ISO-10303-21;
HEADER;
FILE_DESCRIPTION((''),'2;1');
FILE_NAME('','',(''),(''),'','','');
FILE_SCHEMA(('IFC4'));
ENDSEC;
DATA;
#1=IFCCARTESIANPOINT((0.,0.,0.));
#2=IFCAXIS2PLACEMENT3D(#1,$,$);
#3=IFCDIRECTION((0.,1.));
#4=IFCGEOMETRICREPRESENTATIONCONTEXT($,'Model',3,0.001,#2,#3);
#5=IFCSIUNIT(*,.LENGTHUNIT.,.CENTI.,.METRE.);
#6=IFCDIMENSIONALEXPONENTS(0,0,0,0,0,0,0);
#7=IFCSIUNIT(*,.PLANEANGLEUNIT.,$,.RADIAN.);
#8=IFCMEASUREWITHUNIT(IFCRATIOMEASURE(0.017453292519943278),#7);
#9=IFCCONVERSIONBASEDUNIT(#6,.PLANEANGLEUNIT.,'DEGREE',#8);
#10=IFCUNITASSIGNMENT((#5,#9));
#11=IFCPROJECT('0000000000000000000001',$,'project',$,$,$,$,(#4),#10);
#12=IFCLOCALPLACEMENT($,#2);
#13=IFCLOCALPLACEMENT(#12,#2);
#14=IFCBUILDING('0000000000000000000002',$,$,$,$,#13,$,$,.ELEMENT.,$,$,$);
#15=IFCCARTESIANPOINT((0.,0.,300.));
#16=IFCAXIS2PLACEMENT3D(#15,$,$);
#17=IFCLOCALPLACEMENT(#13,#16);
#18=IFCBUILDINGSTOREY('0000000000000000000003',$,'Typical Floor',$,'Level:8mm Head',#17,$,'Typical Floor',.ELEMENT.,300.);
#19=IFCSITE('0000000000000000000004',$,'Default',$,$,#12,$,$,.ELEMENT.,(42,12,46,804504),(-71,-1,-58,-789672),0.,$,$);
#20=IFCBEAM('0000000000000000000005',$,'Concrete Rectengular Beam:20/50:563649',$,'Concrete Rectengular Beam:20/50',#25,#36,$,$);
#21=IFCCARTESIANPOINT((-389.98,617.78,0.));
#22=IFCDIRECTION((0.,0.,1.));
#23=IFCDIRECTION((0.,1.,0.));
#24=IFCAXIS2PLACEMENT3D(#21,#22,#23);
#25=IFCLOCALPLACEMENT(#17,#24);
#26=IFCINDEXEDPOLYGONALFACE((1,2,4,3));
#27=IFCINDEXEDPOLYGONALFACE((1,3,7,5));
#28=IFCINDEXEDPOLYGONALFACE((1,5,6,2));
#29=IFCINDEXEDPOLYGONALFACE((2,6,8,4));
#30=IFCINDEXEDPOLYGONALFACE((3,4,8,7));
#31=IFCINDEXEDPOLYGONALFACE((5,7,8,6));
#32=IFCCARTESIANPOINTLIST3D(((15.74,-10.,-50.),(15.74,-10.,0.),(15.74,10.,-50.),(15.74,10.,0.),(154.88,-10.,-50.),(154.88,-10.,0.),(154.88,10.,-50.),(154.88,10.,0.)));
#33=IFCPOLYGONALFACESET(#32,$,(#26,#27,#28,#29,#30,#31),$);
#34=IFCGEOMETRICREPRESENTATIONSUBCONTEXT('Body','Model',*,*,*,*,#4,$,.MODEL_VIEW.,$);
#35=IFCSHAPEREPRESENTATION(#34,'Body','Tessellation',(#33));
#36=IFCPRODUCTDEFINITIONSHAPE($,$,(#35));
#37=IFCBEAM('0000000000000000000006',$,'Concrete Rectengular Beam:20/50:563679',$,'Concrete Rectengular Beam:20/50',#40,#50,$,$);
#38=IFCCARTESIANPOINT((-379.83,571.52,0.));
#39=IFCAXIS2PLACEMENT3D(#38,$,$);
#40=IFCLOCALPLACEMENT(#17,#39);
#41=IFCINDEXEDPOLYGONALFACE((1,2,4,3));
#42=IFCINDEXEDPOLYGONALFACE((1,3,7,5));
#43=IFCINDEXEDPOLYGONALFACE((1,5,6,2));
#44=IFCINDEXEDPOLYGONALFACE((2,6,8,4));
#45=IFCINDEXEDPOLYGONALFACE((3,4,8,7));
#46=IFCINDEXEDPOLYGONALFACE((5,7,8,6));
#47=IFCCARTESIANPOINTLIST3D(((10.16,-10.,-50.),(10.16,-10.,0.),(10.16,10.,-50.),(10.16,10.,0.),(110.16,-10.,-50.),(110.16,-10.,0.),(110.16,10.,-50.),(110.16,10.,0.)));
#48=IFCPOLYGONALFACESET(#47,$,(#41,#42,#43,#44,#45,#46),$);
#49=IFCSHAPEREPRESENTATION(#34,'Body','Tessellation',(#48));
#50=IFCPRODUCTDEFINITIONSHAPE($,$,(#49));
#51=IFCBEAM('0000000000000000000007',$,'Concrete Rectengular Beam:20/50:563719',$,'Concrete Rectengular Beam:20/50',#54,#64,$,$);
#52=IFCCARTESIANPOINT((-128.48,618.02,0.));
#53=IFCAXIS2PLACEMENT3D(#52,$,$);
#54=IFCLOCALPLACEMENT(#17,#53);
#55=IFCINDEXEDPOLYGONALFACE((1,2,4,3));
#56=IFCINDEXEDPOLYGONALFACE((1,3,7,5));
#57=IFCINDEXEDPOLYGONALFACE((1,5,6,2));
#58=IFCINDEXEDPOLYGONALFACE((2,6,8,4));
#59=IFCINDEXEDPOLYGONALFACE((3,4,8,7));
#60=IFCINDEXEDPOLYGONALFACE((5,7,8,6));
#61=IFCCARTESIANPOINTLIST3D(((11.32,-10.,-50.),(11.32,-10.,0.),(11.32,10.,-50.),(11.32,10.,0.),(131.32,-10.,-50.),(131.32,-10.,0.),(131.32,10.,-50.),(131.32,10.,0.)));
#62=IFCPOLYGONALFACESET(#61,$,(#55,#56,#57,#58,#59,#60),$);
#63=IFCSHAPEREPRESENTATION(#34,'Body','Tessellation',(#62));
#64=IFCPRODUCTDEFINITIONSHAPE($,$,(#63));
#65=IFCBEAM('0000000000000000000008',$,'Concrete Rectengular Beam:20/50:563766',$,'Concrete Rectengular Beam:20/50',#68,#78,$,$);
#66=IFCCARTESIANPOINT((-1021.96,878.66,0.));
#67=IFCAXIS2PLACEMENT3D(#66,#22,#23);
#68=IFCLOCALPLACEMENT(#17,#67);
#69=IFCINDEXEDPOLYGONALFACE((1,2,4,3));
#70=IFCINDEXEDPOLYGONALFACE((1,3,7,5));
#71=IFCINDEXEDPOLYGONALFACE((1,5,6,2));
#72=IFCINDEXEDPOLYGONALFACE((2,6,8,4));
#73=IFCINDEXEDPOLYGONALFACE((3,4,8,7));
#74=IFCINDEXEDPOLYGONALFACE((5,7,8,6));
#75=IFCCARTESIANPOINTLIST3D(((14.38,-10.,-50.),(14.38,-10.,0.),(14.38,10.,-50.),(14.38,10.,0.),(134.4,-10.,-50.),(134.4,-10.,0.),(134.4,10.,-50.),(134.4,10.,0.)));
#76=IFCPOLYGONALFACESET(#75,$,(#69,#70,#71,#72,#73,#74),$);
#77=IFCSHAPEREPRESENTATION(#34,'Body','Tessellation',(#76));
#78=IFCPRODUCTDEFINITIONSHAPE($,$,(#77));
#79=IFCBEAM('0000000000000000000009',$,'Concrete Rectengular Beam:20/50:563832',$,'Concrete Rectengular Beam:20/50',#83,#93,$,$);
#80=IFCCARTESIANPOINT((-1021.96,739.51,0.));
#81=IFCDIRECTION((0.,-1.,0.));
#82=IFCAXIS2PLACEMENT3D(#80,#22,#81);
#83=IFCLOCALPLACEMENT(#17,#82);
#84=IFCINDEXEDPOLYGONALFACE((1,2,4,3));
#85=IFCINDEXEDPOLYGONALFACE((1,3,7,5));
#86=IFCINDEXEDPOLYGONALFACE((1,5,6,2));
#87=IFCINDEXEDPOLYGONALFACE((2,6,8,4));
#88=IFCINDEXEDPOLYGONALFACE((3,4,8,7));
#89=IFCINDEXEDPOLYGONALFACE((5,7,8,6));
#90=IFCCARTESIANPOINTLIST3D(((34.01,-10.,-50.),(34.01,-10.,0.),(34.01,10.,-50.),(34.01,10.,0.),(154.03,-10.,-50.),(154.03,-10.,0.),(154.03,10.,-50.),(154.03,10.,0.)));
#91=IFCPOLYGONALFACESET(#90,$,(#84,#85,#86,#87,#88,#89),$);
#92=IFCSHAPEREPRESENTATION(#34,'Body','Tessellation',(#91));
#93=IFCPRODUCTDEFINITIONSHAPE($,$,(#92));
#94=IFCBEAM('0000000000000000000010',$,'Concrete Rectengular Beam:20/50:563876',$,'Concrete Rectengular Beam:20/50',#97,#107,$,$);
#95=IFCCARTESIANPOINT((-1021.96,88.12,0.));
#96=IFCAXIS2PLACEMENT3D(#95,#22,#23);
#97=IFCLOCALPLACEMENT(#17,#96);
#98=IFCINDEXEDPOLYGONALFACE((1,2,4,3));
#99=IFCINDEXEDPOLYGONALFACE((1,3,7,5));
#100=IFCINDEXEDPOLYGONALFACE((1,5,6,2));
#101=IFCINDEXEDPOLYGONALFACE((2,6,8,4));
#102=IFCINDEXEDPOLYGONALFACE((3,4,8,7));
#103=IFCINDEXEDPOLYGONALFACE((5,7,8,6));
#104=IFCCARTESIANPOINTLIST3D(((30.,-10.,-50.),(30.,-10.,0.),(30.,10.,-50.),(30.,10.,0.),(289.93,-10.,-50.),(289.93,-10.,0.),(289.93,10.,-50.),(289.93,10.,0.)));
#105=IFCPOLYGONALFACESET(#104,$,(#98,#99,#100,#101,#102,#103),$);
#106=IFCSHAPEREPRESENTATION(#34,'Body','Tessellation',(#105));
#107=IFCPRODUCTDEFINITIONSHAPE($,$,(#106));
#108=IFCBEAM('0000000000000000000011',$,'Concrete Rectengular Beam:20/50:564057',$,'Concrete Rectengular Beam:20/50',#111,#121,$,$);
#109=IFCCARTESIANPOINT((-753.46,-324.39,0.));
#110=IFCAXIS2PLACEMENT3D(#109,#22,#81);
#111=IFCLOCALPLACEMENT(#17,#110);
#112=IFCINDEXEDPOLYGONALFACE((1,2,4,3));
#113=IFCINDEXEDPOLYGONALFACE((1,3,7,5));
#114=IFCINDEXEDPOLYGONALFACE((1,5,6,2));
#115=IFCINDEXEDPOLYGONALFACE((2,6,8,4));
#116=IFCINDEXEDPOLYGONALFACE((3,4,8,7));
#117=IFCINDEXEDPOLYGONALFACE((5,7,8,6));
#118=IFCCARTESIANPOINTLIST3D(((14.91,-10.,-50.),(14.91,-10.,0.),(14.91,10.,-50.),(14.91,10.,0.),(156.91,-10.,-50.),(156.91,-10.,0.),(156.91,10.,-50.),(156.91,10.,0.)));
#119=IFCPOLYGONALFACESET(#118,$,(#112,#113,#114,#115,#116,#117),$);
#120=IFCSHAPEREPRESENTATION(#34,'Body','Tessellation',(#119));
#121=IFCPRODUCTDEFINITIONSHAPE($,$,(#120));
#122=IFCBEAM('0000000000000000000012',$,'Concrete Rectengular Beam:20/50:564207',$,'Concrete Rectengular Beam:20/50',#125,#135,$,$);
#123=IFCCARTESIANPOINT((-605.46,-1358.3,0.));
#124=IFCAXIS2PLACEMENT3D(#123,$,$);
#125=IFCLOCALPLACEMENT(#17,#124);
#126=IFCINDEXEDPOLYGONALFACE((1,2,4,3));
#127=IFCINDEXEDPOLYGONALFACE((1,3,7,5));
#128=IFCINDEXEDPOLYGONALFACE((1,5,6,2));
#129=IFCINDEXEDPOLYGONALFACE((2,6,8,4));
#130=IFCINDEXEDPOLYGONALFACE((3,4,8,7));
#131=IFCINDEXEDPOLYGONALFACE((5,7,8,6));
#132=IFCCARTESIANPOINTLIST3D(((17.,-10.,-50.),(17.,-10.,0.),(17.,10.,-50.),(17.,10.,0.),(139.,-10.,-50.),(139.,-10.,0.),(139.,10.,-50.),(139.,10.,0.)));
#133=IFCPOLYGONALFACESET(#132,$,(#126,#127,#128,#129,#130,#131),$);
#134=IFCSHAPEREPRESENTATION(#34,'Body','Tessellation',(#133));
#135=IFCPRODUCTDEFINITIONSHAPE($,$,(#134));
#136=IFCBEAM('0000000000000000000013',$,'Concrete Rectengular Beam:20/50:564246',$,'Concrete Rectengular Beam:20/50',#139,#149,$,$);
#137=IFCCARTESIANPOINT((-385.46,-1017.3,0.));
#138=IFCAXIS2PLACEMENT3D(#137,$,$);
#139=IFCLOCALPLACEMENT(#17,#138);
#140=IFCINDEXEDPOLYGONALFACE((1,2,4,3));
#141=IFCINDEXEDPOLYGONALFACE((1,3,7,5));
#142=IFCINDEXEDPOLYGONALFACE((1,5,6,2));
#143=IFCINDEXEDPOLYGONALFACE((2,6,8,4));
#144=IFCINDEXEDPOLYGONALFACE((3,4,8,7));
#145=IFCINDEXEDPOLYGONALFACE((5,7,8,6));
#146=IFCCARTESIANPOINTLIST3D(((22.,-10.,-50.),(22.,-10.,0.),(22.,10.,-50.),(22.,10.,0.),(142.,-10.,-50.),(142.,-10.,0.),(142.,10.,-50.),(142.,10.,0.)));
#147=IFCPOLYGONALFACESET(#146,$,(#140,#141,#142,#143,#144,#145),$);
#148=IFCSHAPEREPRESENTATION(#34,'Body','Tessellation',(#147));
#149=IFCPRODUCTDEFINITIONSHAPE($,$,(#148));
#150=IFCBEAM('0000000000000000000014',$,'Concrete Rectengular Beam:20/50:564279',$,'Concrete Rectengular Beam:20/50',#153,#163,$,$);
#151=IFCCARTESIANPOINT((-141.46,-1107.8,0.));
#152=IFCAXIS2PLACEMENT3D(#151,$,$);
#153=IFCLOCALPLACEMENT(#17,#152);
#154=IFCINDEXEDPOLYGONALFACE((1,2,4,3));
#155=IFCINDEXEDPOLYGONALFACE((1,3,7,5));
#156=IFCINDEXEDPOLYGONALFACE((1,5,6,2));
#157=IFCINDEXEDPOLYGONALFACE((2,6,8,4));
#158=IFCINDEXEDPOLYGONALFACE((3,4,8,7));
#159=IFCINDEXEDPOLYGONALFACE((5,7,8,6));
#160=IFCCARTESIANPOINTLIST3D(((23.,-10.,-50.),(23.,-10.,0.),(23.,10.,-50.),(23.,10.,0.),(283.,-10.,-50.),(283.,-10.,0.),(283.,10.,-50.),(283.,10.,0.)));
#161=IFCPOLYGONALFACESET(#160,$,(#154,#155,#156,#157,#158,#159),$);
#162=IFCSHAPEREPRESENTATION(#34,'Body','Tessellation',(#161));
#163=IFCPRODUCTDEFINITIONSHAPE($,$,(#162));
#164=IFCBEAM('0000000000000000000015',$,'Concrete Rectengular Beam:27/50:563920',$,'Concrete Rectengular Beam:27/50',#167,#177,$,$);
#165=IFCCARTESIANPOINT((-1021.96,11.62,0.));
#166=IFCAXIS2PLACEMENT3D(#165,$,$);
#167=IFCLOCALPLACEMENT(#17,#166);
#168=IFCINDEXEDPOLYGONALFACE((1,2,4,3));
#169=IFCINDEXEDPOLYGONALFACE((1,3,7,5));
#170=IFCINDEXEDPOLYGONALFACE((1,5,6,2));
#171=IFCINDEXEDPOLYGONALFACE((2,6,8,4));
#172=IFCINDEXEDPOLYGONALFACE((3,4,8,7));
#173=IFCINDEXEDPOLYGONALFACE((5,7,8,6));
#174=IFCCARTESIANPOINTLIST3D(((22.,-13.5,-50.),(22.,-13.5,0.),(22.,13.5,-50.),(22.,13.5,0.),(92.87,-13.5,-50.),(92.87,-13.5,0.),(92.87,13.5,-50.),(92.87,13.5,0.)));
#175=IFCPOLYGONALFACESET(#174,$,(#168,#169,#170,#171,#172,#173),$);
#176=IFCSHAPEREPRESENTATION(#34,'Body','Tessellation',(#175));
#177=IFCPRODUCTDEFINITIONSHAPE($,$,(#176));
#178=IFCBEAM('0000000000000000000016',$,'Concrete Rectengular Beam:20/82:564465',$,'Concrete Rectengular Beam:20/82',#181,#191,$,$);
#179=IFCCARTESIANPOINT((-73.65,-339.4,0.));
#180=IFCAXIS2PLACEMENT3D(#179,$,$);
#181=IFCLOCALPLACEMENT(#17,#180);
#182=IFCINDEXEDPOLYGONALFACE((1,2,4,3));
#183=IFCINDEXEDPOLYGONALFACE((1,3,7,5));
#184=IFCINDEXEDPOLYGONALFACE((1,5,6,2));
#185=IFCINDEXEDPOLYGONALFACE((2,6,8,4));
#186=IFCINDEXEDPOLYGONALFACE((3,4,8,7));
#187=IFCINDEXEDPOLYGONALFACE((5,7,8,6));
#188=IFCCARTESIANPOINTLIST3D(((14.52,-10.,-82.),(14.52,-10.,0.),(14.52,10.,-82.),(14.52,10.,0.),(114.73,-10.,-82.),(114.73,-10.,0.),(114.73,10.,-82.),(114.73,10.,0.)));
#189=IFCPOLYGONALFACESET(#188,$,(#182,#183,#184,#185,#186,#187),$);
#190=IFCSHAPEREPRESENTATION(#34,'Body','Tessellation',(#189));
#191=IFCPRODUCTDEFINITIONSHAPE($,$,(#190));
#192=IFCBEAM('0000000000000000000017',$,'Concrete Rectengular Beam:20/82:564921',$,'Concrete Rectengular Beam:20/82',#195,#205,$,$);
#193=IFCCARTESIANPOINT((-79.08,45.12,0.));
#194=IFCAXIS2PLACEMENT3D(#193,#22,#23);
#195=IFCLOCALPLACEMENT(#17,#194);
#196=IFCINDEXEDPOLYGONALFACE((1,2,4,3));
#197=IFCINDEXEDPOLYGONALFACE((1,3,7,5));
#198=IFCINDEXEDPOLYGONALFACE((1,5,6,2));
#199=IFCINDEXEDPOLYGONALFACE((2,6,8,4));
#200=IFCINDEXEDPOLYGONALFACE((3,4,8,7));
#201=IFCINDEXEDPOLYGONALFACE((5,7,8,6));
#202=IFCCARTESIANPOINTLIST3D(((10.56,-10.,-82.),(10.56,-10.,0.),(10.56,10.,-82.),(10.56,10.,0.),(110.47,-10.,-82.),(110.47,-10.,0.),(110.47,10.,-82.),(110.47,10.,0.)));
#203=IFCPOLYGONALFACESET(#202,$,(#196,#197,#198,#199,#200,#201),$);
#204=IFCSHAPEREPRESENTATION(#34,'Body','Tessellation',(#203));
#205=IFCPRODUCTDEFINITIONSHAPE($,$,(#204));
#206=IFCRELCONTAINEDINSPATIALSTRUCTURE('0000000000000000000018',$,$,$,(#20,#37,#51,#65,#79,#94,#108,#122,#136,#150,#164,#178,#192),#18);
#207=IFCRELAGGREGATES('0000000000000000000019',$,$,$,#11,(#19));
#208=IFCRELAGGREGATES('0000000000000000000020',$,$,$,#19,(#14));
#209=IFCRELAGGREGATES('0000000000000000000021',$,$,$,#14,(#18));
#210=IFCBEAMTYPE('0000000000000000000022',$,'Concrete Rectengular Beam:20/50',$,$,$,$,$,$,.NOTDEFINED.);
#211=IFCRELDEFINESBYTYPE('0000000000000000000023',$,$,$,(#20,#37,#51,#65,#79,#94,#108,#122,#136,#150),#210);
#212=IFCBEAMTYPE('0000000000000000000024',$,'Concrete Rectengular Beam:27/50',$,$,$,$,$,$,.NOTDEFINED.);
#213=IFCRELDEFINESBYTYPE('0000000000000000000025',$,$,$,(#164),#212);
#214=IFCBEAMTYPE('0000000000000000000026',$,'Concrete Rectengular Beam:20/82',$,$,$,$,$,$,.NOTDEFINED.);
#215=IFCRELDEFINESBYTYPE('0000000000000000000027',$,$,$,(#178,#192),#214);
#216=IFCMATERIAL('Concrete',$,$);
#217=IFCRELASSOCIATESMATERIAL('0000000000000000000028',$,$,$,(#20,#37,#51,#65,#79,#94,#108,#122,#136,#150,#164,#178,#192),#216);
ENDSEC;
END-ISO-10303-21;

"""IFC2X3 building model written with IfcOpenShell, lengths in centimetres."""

from ifc_helpers import new_model, entity, si_unit, converted_unit, direction, frame, frame_2d, origin, origin_2d_with_axis, place, context, subcontext, project, spatial, rectangle, extrude, material, type_object, element, save


model = new_model("IFC2X3")

# Units and contexts
model_context = context("Model", 3, precision=0.001, world=origin(), true_north=direction((0.0, 1.0)))
body_context = subcontext(model_context, "Body", "Model", "MODEL_VIEW")
ifc_project = project(units=[si_unit("LENGTHUNIT", "METRE", prefix="CENTI"), converted_unit("PLANEANGLEUNIT", "DEGREE", entity("IfcRatioMeasure", 0.017453292519943278), si_unit("PLANEANGLEUNIT", "RADIAN"), dimensions=[0, 0, 0, 0, 0, 0, 0])], contexts=[model_context])

# Site, building, storey
site_placement = place(None, origin())
site = spatial("IfcSite", under=ifc_project, at=site_placement, Name="Default", CompositionType="ELEMENT", RefLatitude=(42, 12, 46, 804504), RefLongitude=(-71, -1, -58, -789672), RefElevation=0.0)
building_placement = place(site_placement, origin())
building = spatial("IfcBuilding", under=site, at=building_placement, CompositionType="ELEMENT")
storey_placement = place(building_placement, frame((0.0, 0.0, 300.0)))
storey = spatial("IfcBuildingStorey", under=building, at=storey_placement, Name="Typical Floor", ObjectType="Level:8mm Head", LongName="Typical Floor", CompositionType="ELEMENT", Elevation=300.0)

# Beams
ifc_material = material(Name="Concrete")
beam_type_1 = type_object("IfcBeamType", Name="Concrete Rectengular Beam:20/50", PredefinedType="NOTDEFINED")
beam_1_placement = place(storey_placement, frame((-389.98, 617.78, 0.0), z_axis=(0.0, 0.0, 1.0), x_axis=(0.0, 1.0, 0.0)))
element("IfcBeam", 1, at=beam_1_placement, inside=storey, type_object=beam_type_1, material=ifc_material, Name="Concrete Rectengular Beam:20/50:563649", ObjectType="Concrete Rectengular Beam:20/50", context=body_context, shape_type="SweptSolid", body=[
    extrude(rectangle(XDim=50.0, YDim=20.0, at=frame_2d((0.0, 0.0), x_axis=(1.0, 0.0))), frame((15.74, 0.0, -25.0), z_axis=(1.0, 0.0, 0.0), x_axis=(0.0, 0.0, -1.0)), (0.0, 0.0, 1.0), 139.14),
])
beam_2_placement = place(storey_placement, frame((-379.83, 571.52, 0.0)))
element("IfcBeam", 2, at=beam_2_placement, inside=storey, type_object=beam_type_1, material=ifc_material, Name="Concrete Rectengular Beam:20/50:563679", ObjectType="Concrete Rectengular Beam:20/50", context=body_context, shape_type="SweptSolid", body=[
    extrude(rectangle(XDim=50.0, YDim=20.0, at=frame_2d((0.0, 0.0), x_axis=(1.0, 0.0))), frame((10.16, 0.0, -25.0), z_axis=(1.0, 0.0, 0.0), x_axis=(0.0, 0.0, -1.0)), (0.0, 0.0, 1.0), 100.0),
])
beam_3_placement = place(storey_placement, frame((-128.48, 618.02, 0.0)))
element("IfcBeam", 3, at=beam_3_placement, inside=storey, type_object=beam_type_1, material=ifc_material, Name="Concrete Rectengular Beam:20/50:563719", ObjectType="Concrete Rectengular Beam:20/50", context=body_context, shape_type="SweptSolid", body=[
    extrude(rectangle(XDim=50.0, YDim=20.0, at=frame_2d((0.0, 0.0), x_axis=(1.0, 0.0))), frame((11.32, 0.0, -25.0), z_axis=(1.0, 0.0, 0.0), x_axis=(0.0, 0.0, -1.0)), (0.0, 0.0, 1.0), 120.0),
])
beam_4_placement = place(storey_placement, frame((-1021.96, 878.66, 0.0), z_axis=(0.0, 0.0, 1.0), x_axis=(0.0, 1.0, 0.0)))
element("IfcBeam", 4, at=beam_4_placement, inside=storey, type_object=beam_type_1, material=ifc_material, Name="Concrete Rectengular Beam:20/50:563766", ObjectType="Concrete Rectengular Beam:20/50", context=body_context, shape_type="SweptSolid", body=[
    extrude(rectangle(XDim=50.0, YDim=20.0, at=frame_2d((0.0, 0.0), x_axis=(1.0, 0.0))), frame((14.38, 0.0, -25.0), z_axis=(1.0, 0.0, 0.0), x_axis=(0.0, 0.0, -1.0)), (0.0, 0.0, 1.0), 120.02),
])
beam_5_placement = place(storey_placement, frame((-1021.96, 739.51, 0.0), z_axis=(0.0, 0.0, 1.0), x_axis=(0.0, -1.0, 0.0)))
element("IfcBeam", 5, at=beam_5_placement, inside=storey, type_object=beam_type_1, material=ifc_material, Name="Concrete Rectengular Beam:20/50:563832", ObjectType="Concrete Rectengular Beam:20/50", context=body_context, shape_type="SweptSolid", body=[
    extrude(rectangle(XDim=50.0, YDim=20.0, at=frame_2d((0.0, 0.0), x_axis=(1.0, 0.0))), frame((34.01, 0.0, -25.0), z_axis=(1.0, 0.0, 0.0), x_axis=(0.0, 0.0, -1.0)), (0.0, 0.0, 1.0), 120.02),
])
beam_6_placement = place(storey_placement, frame((-1021.96, 88.12, 0.0), z_axis=(0.0, 0.0, 1.0), x_axis=(0.0, 1.0, 0.0)))
element("IfcBeam", 6, at=beam_6_placement, inside=storey, type_object=beam_type_1, material=ifc_material, Name="Concrete Rectengular Beam:20/50:563876", ObjectType="Concrete Rectengular Beam:20/50", context=body_context, shape_type="SweptSolid", body=[
    extrude(rectangle(XDim=50.0, YDim=20.0, at=origin_2d_with_axis()), frame((30.0, 0.0, -25.0), z_axis=(1.0, 0.0, 0.0), x_axis=(0.0, 0.0, -1.0)), (0.0, 0.0, 1.0), 259.93),
])
beam_7_placement = place(storey_placement, frame((-753.46, -324.39, 0.0), z_axis=(0.0, 0.0, 1.0), x_axis=(0.0, -1.0, 0.0)))
element("IfcBeam", 7, at=beam_7_placement, inside=storey, type_object=beam_type_1, material=ifc_material, Name="Concrete Rectengular Beam:20/50:564057", ObjectType="Concrete Rectengular Beam:20/50", context=body_context, shape_type="SweptSolid", body=[
    extrude(rectangle(XDim=50.0, YDim=20.0, at=frame_2d((0.0, 0.0), x_axis=(1.0, 0.0))), frame((14.91, 0.0, -25.0), z_axis=(1.0, 0.0, 0.0), x_axis=(0.0, 0.0, -1.0)), (0.0, 0.0, 1.0), 142.0),
])
beam_8_placement = place(storey_placement, frame((-605.46, -1358.3, 0.0)))
element("IfcBeam", 8, at=beam_8_placement, inside=storey, type_object=beam_type_1, material=ifc_material, Name="Concrete Rectengular Beam:20/50:564207", ObjectType="Concrete Rectengular Beam:20/50", context=body_context, shape_type="SweptSolid", body=[
    extrude(rectangle(XDim=50.0, YDim=20.0, at=frame_2d((0.0, 0.0), x_axis=(1.0, 0.0))), frame((17.0, 0.0, -25.0), z_axis=(1.0, 0.0, 0.0), x_axis=(0.0, 0.0, -1.0)), (0.0, 0.0, 1.0), 122.0),
])
beam_9_placement = place(storey_placement, frame((-385.46, -1017.3, 0.0)))
element("IfcBeam", 9, at=beam_9_placement, inside=storey, type_object=beam_type_1, material=ifc_material, Name="Concrete Rectengular Beam:20/50:564246", ObjectType="Concrete Rectengular Beam:20/50", context=body_context, shape_type="SweptSolid", body=[
    extrude(rectangle(XDim=50.0, YDim=20.0, at=frame_2d((0.0, 0.0), x_axis=(1.0, 0.0))), frame((22.0, 0.0, -25.0), z_axis=(1.0, 0.0, 0.0), x_axis=(0.0, 0.0, -1.0)), (0.0, 0.0, 1.0), 120.0),
])
beam_10_placement = place(storey_placement, frame((-141.46, -1107.8, 0.0)))
element("IfcBeam", 10, at=beam_10_placement, inside=storey, type_object=beam_type_1, material=ifc_material, Name="Concrete Rectengular Beam:20/50:564279", ObjectType="Concrete Rectengular Beam:20/50", context=body_context, shape_type="SweptSolid", body=[
    extrude(rectangle(XDim=50.0, YDim=20.0, at=frame_2d((0.0, 0.0), x_axis=(1.0, 0.0))), frame((23.0, 0.0, -25.0), z_axis=(1.0, 0.0, 0.0), x_axis=(0.0, 0.0, -1.0)), (0.0, 0.0, 1.0), 260.0),
])
beam_type_2 = type_object("IfcBeamType", Name="Concrete Rectengular Beam:27/50", PredefinedType="NOTDEFINED")
beam_11_placement = place(storey_placement, frame((-1021.96, 11.62, 0.0)))
element("IfcBeam", 11, at=beam_11_placement, inside=storey, type_object=beam_type_2, material=ifc_material, Name="Concrete Rectengular Beam:27/50:563920", ObjectType="Concrete Rectengular Beam:27/50", context=body_context, shape_type="SweptSolid", body=[
    extrude(rectangle(XDim=50.0, YDim=27.0, at=frame_2d((0.0, 0.0), x_axis=(1.0, 0.0))), frame((22.0, 0.0, -25.0), z_axis=(1.0, 0.0, 0.0), x_axis=(0.0, 0.0, -1.0)), (0.0, 0.0, 1.0), 70.87),
])
beam_type_3 = type_object("IfcBeamType", Name="Concrete Rectengular Beam:20/82", PredefinedType="NOTDEFINED")
beam_12_placement = place(storey_placement, frame((-73.65, -339.4, 0.0)))
element("IfcBeam", 12, at=beam_12_placement, inside=storey, type_object=beam_type_3, material=ifc_material, Name="Concrete Rectengular Beam:20/82:564465", ObjectType="Concrete Rectengular Beam:20/82", context=body_context, shape_type="SweptSolid", body=[
    extrude(rectangle(XDim=82.0, YDim=20.0, at=frame_2d((0.0, 0.0), x_axis=(1.0, 0.0))), frame((14.52, 0.0, -41.0), z_axis=(1.0, 0.0, 0.0), x_axis=(0.0, 0.0, -1.0)), (0.0, 0.0, 1.0), 100.21),
])
beam_13_placement = place(storey_placement, frame((-79.08, 45.12, 0.0), z_axis=(0.0, 0.0, 1.0), x_axis=(0.0, 1.0, 0.0)))
element("IfcBeam", 13, at=beam_13_placement, inside=storey, type_object=beam_type_3, material=ifc_material, Name="Concrete Rectengular Beam:20/82:564921", ObjectType="Concrete Rectengular Beam:20/82", context=body_context, shape_type="SweptSolid", body=[
    extrude(rectangle(XDim=82.0, YDim=20.0, at=origin_2d_with_axis()), frame((10.56, 0.0, -41.0), z_axis=(1.0, 0.0, 0.0), x_axis=(0.0, 0.0, -1.0)), (0.0, 0.0, 1.0), 99.91),
])

save(model, "model.ifc")
